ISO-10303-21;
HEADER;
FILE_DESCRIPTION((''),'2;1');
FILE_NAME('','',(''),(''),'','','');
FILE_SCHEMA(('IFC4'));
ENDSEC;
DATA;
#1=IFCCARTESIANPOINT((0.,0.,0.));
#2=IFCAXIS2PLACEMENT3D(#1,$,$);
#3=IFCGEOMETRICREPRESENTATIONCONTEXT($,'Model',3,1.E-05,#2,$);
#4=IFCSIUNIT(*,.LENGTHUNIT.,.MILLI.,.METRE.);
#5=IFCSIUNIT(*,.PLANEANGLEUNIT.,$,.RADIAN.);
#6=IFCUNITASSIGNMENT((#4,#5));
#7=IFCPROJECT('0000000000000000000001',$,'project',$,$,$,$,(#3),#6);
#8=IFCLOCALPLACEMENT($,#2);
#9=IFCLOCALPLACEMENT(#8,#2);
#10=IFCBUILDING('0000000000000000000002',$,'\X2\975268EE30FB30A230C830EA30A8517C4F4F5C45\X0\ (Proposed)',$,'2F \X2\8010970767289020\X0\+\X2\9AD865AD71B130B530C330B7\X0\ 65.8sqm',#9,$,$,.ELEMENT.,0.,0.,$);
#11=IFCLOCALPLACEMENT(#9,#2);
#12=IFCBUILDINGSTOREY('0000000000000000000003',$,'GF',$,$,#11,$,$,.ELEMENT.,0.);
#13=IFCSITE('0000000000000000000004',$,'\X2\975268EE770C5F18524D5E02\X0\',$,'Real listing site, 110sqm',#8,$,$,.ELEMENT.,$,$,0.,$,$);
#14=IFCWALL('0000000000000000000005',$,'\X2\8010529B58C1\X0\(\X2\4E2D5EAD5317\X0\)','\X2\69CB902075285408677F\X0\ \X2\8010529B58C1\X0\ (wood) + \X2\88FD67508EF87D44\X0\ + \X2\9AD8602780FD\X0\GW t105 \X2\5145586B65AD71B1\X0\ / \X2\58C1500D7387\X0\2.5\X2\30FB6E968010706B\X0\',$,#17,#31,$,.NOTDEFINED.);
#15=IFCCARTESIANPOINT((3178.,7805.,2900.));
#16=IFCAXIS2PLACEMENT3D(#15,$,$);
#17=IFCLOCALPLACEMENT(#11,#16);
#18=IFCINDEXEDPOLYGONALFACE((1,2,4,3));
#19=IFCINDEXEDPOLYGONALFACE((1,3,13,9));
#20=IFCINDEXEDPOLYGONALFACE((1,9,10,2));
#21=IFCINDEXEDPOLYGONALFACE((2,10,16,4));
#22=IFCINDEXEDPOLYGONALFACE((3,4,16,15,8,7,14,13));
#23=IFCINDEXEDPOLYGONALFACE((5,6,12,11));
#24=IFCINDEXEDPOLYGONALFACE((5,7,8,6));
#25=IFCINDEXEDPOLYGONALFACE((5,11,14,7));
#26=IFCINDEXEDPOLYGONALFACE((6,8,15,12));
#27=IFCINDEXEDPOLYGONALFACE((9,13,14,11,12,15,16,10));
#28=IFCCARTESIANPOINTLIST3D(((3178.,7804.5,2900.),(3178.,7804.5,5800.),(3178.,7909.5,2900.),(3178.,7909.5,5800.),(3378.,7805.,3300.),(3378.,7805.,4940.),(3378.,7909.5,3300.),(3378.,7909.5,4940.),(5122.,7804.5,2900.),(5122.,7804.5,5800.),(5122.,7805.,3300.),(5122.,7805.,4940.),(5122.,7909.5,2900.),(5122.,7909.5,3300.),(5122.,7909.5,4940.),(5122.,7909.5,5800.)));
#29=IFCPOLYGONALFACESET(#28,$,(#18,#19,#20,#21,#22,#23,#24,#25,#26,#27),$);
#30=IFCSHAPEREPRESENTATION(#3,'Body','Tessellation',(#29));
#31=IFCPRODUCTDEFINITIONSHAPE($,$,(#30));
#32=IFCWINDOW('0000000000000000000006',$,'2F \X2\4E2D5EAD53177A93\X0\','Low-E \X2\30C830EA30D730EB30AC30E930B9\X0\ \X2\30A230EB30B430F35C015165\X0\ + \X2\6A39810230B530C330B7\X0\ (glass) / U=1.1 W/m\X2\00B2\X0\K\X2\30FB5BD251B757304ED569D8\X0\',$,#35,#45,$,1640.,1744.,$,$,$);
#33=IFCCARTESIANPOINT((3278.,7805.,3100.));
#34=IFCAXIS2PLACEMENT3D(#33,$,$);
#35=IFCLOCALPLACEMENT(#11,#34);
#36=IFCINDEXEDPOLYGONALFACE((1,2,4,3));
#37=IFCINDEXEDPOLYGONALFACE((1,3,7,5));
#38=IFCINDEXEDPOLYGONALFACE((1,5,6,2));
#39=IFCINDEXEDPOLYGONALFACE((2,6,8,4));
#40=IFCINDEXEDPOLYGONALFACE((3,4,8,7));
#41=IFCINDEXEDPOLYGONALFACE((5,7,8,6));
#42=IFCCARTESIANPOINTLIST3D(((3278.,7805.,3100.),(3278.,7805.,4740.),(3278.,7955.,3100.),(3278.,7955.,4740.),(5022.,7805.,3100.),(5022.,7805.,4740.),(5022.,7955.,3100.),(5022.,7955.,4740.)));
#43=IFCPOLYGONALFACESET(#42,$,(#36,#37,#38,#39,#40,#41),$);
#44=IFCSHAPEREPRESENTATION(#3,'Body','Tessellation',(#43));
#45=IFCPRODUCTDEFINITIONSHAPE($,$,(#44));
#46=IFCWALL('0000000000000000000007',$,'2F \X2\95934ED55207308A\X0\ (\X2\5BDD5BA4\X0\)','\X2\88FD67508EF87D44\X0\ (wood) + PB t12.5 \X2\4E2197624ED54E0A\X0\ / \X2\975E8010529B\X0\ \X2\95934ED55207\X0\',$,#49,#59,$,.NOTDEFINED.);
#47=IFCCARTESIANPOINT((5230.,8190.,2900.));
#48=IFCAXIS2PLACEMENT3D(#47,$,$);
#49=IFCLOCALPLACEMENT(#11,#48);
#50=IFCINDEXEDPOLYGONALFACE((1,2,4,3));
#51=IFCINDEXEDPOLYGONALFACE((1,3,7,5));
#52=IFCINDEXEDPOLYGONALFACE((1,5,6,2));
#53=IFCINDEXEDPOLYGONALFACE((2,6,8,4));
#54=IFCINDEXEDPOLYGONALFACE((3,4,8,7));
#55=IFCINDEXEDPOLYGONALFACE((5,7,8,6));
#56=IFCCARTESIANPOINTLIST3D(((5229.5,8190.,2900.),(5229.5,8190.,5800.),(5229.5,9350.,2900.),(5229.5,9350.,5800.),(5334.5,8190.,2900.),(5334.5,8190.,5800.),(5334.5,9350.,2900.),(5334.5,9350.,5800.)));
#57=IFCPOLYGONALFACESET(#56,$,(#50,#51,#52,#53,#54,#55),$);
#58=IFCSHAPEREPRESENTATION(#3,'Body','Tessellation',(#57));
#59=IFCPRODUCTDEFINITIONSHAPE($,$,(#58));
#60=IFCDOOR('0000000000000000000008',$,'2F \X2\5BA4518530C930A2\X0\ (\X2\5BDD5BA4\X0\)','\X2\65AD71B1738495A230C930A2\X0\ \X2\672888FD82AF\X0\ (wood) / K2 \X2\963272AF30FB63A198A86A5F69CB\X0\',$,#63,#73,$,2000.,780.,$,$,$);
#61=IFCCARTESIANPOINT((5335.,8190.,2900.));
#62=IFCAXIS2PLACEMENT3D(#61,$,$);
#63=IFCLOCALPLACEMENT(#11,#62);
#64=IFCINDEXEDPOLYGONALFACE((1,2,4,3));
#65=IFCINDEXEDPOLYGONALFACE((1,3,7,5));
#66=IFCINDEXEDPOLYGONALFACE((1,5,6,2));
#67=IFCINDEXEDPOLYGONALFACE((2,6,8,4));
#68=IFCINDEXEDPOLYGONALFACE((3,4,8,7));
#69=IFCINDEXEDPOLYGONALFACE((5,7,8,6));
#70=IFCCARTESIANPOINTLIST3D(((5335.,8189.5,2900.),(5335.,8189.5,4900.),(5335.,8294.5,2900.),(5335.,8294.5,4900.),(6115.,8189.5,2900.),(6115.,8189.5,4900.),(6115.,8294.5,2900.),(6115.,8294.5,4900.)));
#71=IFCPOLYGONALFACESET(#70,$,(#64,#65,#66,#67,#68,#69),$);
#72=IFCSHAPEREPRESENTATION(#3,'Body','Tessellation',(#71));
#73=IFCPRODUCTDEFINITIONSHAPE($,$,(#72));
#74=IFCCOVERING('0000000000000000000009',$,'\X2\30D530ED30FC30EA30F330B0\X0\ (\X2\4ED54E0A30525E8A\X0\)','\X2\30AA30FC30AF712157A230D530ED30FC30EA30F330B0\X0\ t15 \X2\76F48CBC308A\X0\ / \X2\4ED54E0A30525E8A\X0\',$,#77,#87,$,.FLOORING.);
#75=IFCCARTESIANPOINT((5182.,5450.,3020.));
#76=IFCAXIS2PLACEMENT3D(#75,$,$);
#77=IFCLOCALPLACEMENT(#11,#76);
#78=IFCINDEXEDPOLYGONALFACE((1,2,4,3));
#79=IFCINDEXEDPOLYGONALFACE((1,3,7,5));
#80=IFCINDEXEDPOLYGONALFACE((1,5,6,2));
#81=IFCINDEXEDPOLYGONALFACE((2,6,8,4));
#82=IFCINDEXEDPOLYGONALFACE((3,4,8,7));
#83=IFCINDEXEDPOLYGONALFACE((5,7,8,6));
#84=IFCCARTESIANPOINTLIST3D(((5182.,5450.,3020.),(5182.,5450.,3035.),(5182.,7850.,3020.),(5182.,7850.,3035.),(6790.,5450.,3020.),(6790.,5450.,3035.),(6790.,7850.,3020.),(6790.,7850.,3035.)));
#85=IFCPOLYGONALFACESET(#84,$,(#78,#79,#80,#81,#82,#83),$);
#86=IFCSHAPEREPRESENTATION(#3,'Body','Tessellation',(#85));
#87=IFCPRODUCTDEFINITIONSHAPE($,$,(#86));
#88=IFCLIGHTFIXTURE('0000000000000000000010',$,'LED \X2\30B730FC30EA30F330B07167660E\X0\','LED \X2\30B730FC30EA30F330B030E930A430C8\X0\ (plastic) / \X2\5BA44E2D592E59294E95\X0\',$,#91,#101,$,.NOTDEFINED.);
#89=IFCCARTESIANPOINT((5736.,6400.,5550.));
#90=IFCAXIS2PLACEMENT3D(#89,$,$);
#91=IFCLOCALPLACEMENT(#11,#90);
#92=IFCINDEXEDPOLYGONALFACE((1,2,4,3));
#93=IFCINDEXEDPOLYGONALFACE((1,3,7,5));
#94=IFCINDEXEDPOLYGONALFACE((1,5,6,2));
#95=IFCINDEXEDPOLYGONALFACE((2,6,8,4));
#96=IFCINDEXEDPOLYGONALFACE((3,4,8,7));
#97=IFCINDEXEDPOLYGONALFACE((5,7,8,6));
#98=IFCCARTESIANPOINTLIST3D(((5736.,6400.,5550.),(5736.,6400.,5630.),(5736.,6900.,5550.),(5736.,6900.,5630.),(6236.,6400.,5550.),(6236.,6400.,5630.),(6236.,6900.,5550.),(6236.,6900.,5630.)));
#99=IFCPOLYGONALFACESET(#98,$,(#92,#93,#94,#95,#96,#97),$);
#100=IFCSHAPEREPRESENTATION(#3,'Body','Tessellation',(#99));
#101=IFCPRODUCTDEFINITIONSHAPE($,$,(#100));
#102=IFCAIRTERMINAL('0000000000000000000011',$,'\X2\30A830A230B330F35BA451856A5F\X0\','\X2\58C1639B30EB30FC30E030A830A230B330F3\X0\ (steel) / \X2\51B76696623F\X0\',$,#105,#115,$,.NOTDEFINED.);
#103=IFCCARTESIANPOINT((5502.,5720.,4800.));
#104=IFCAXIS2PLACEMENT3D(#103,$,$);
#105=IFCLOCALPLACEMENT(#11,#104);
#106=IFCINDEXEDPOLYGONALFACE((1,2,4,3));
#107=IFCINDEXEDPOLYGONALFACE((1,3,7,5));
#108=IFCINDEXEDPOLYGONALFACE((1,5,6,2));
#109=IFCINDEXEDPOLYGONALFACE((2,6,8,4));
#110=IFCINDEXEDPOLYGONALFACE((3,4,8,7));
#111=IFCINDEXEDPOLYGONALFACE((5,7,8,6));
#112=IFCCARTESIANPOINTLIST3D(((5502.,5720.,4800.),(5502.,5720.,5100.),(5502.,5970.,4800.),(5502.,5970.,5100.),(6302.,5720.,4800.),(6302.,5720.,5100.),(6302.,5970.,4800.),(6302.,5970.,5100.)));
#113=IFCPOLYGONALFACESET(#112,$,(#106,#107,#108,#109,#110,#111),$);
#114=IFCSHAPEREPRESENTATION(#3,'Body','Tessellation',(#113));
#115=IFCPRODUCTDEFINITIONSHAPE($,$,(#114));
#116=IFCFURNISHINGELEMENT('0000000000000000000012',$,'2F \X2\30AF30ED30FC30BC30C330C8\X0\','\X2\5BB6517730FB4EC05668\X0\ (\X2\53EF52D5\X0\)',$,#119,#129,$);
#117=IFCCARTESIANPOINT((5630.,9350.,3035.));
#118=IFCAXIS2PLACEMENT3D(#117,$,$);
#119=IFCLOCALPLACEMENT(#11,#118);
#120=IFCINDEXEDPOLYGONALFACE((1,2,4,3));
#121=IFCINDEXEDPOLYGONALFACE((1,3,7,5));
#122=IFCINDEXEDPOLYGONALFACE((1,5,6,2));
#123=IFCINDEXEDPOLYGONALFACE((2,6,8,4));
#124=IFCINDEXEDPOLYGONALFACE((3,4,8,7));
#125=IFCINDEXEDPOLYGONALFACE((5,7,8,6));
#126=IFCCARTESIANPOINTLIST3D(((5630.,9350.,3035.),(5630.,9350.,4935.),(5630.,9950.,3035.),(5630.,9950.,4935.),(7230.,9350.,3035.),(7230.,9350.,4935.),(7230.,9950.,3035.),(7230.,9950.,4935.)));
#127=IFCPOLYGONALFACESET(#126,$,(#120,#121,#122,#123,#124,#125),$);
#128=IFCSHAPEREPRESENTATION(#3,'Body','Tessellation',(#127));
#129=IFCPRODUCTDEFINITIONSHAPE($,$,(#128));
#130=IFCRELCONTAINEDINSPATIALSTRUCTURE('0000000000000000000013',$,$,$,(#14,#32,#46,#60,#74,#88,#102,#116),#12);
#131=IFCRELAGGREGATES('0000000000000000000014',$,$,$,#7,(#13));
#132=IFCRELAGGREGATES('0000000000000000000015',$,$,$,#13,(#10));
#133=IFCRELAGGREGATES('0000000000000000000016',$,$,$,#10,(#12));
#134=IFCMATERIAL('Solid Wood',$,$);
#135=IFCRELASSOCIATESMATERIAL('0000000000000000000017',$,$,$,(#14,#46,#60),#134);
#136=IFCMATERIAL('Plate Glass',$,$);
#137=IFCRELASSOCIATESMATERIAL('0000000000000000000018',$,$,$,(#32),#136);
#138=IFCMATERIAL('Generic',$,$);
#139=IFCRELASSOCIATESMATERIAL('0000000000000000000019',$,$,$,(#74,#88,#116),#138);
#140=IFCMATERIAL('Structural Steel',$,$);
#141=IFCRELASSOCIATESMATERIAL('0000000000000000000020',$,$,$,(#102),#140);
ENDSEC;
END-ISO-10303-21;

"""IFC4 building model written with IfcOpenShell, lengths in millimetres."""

from ifc_helpers import new_model, si_unit, frame, frame_2d, origin, place, context, project, spatial, rectangle, extrude, material, element, fill, save


model = new_model("IFC4")

# Units and contexts
model_context = context("Model", 3, precision=1e-05, world=origin())
ifc_project = project(units=[si_unit("LENGTHUNIT", "METRE", prefix="MILLI"), si_unit("PLANEANGLEUNIT", "RADIAN")], contexts=[model_context])

# Site, building, storey
site_placement = place(None, origin())
site = spatial("IfcSite", under=ifc_project, at=site_placement, Name="青森県弘前市", ObjectType="Real listing site, 110sqm", CompositionType="ELEMENT", RefElevation=0.0)
building_placement = place(site_placement, origin())
building = spatial("IfcBuilding", under=site, at=building_placement, Name="青森・アトリエ兼住居 (Proposed)", ObjectType="2F 耐震木造+高断熱サッシ 65.8sqm", CompositionType="ELEMENT", ElevationOfRefHeight=0.0, ElevationOfTerrain=0.0)
storey_placement = place(building_placement, origin())
storey = spatial("IfcBuildingStorey", under=building, at=storey_placement, Name="GF", CompositionType="ELEMENT", Elevation=0.0)

# Shared definitions
ifc_material_1 = material(Name="Solid Wood")

# Wall, opening, window
wall_1_placement = place(storey_placement, frame((3178.0, 7805.0, 2900.0)))
wall_1 = element("IfcWall", 1, at=wall_1_placement, inside=storey, material=ifc_material_1, Name="耐力壁(中庭北)", Description="構造用合板 耐力壁 (wood) + 製材軸組 + 高性能GW t105 充填断熱 / 壁倍率2.5・準耐火", PredefinedType="NOTDEFINED", context=model_context, shape_type="SweptSolid", body=[
    extrude(rectangle(XDim=1944.0, YDim=105.0, at=frame_2d((972.0, 52.0))), frame((3178.0, 7805.0, 2900.0)), (0.0, 0.0, 1.0), 2900.0),
])
opening_placement = place(storey_placement, frame((3278.0, 7805.0, 3100.0)))
opening = element("IfcOpeningElement", 2, at=opening_placement, cuts=wall_1, PredefinedType="NOTDEFINED", context=model_context, shape_type="SweptSolid", body=[
    extrude(rectangle(XDim=1744.0, YDim=150.0, at=frame_2d((872.0, 75.0))), frame((3278.0, 7805.0, 3100.0)), (0.0, 0.0, 1.0), 1640.0),
])
ifc_material_2 = material(Name="Plate Glass")
window_placement = place(storey_placement, frame((3278.0, 7805.0, 3100.0)))
window = element("IfcWindow", 3, at=window_placement, inside=storey, material=ifc_material_2, Name="2F 中庭北窓", Description="Low-E トリプルガラス アルゴン封入 + 樹脂サッシ (glass) / U=1.1 W/m²K・寒冷地仕様", OverallHeight=1640.0, OverallWidth=1744.0, context=model_context, shape_type="SweptSolid", body=[
    extrude(rectangle(XDim=1744.0, YDim=150.0, at=frame_2d((872.0, 75.0))), frame((3278.0, 7805.0, 3100.0)), (0.0, 0.0, 1.0), 1640.0),
])
fill(opening, window)

# Wall
wall_2_placement = place(storey_placement, frame((5230.0, 8190.0, 2900.0)))
element("IfcWall", 4, at=wall_2_placement, inside=storey, material=ifc_material_1, Name="2F 間仕切り (寝室)", Description="製材軸組 (wood) + PB t12.5 両面仕上 / 非耐力 間仕切", PredefinedType="NOTDEFINED", context=model_context, shape_type="SweptSolid", body=[
    extrude(rectangle(XDim=105.0, YDim=1160.0, at=frame_2d((52.0, 580.0))), frame((5230.0, 8190.0, 2900.0)), (0.0, 0.0, 1.0), 2900.0),
])

# Door
door_placement = place(storey_placement, frame((5335.0, 8190.0, 2900.0)))
element("IfcDoor", 5, at=door_placement, inside=storey, material=ifc_material_1, Name="2F 室内ドア (寝室)", Description="断熱玄関ドア 木製芯 (wood) / K2 防犯・採風機構", OverallHeight=2000.0, OverallWidth=780.0, context=model_context, shape_type="SweptSolid", body=[
    extrude(rectangle(XDim=780.0, YDim=105.0, at=frame_2d((390.0, 52.0))), frame((5335.0, 8190.0, 2900.0)), (0.0, 0.0, 1.0), 2000.0),
])

# Covering
ifc_material_3 = material(Name="Generic")
covering_placement = place(storey_placement, frame((5182.0, 5450.0, 3020.0)))
element("IfcCovering", 6, at=covering_placement, inside=storey, material=ifc_material_3, Name="フローリング (仕上げ床)", Description="オーク無垢フローリング t15 直貼り / 仕上げ床", PredefinedType="FLOORING", context=model_context, shape_type="SweptSolid", body=[
    extrude(rectangle(XDim=1608.0, YDim=2400.0, at=frame_2d((804.0, 1200.0))), frame((5182.0, 5450.0, 3020.0)), (0.0, 0.0, 1.0), 15.0),
])

# Light fixture
light_fixture_placement = place(storey_placement, frame((5736.0, 6400.0, 5550.0)))
element("IfcLightFixture", 7, at=light_fixture_placement, inside=storey, material=ifc_material_3, Name="LED シーリング照明", Description="LED シーリングライト (plastic) / 室中央天井", PredefinedType="NOTDEFINED", context=model_context, shape_type="SweptSolid", body=[
    extrude(rectangle(XDim=500.0, YDim=500.0, at=frame_2d((250.0, 250.0))), frame((5736.0, 6400.0, 5550.0)), (0.0, 0.0, 1.0), 80.0),
])

# Air terminal
ifc_material_4 = material(Name="Structural Steel")
air_terminal_placement = place(storey_placement, frame((5502.0, 5720.0, 4800.0)))
element("IfcAirTerminal", 8, at=air_terminal_placement, inside=storey, material=ifc_material_4, Name="エアコン室内機", Description="壁掛ルームエアコン (steel) / 冷暖房", PredefinedType="NOTDEFINED", context=model_context, shape_type="SweptSolid", body=[
    extrude(rectangle(XDim=800.0, YDim=250.0, at=frame_2d((400.0, 125.0))), frame((5502.0, 5720.0, 4800.0)), (0.0, 0.0, 1.0), 300.0),
])

# Furnishing element
furnishing_placement = place(storey_placement, frame((5630.0, 9350.0, 3035.0)))
element("IfcFurnishingElement", 9, at=furnishing_placement, inside=storey, material=ifc_material_3, Name="2F クローゼット", Description="家具・什器 (可動)", context=model_context, shape_type="SweptSolid", body=[
    extrude(rectangle(XDim=1600.0, YDim=600.0, at=frame_2d((800.0, 300.0))), frame((5630.0, 9350.0, 3035.0)), (0.0, 0.0, 1.0), 1900.0),
])

save(model, "model.ifc")
